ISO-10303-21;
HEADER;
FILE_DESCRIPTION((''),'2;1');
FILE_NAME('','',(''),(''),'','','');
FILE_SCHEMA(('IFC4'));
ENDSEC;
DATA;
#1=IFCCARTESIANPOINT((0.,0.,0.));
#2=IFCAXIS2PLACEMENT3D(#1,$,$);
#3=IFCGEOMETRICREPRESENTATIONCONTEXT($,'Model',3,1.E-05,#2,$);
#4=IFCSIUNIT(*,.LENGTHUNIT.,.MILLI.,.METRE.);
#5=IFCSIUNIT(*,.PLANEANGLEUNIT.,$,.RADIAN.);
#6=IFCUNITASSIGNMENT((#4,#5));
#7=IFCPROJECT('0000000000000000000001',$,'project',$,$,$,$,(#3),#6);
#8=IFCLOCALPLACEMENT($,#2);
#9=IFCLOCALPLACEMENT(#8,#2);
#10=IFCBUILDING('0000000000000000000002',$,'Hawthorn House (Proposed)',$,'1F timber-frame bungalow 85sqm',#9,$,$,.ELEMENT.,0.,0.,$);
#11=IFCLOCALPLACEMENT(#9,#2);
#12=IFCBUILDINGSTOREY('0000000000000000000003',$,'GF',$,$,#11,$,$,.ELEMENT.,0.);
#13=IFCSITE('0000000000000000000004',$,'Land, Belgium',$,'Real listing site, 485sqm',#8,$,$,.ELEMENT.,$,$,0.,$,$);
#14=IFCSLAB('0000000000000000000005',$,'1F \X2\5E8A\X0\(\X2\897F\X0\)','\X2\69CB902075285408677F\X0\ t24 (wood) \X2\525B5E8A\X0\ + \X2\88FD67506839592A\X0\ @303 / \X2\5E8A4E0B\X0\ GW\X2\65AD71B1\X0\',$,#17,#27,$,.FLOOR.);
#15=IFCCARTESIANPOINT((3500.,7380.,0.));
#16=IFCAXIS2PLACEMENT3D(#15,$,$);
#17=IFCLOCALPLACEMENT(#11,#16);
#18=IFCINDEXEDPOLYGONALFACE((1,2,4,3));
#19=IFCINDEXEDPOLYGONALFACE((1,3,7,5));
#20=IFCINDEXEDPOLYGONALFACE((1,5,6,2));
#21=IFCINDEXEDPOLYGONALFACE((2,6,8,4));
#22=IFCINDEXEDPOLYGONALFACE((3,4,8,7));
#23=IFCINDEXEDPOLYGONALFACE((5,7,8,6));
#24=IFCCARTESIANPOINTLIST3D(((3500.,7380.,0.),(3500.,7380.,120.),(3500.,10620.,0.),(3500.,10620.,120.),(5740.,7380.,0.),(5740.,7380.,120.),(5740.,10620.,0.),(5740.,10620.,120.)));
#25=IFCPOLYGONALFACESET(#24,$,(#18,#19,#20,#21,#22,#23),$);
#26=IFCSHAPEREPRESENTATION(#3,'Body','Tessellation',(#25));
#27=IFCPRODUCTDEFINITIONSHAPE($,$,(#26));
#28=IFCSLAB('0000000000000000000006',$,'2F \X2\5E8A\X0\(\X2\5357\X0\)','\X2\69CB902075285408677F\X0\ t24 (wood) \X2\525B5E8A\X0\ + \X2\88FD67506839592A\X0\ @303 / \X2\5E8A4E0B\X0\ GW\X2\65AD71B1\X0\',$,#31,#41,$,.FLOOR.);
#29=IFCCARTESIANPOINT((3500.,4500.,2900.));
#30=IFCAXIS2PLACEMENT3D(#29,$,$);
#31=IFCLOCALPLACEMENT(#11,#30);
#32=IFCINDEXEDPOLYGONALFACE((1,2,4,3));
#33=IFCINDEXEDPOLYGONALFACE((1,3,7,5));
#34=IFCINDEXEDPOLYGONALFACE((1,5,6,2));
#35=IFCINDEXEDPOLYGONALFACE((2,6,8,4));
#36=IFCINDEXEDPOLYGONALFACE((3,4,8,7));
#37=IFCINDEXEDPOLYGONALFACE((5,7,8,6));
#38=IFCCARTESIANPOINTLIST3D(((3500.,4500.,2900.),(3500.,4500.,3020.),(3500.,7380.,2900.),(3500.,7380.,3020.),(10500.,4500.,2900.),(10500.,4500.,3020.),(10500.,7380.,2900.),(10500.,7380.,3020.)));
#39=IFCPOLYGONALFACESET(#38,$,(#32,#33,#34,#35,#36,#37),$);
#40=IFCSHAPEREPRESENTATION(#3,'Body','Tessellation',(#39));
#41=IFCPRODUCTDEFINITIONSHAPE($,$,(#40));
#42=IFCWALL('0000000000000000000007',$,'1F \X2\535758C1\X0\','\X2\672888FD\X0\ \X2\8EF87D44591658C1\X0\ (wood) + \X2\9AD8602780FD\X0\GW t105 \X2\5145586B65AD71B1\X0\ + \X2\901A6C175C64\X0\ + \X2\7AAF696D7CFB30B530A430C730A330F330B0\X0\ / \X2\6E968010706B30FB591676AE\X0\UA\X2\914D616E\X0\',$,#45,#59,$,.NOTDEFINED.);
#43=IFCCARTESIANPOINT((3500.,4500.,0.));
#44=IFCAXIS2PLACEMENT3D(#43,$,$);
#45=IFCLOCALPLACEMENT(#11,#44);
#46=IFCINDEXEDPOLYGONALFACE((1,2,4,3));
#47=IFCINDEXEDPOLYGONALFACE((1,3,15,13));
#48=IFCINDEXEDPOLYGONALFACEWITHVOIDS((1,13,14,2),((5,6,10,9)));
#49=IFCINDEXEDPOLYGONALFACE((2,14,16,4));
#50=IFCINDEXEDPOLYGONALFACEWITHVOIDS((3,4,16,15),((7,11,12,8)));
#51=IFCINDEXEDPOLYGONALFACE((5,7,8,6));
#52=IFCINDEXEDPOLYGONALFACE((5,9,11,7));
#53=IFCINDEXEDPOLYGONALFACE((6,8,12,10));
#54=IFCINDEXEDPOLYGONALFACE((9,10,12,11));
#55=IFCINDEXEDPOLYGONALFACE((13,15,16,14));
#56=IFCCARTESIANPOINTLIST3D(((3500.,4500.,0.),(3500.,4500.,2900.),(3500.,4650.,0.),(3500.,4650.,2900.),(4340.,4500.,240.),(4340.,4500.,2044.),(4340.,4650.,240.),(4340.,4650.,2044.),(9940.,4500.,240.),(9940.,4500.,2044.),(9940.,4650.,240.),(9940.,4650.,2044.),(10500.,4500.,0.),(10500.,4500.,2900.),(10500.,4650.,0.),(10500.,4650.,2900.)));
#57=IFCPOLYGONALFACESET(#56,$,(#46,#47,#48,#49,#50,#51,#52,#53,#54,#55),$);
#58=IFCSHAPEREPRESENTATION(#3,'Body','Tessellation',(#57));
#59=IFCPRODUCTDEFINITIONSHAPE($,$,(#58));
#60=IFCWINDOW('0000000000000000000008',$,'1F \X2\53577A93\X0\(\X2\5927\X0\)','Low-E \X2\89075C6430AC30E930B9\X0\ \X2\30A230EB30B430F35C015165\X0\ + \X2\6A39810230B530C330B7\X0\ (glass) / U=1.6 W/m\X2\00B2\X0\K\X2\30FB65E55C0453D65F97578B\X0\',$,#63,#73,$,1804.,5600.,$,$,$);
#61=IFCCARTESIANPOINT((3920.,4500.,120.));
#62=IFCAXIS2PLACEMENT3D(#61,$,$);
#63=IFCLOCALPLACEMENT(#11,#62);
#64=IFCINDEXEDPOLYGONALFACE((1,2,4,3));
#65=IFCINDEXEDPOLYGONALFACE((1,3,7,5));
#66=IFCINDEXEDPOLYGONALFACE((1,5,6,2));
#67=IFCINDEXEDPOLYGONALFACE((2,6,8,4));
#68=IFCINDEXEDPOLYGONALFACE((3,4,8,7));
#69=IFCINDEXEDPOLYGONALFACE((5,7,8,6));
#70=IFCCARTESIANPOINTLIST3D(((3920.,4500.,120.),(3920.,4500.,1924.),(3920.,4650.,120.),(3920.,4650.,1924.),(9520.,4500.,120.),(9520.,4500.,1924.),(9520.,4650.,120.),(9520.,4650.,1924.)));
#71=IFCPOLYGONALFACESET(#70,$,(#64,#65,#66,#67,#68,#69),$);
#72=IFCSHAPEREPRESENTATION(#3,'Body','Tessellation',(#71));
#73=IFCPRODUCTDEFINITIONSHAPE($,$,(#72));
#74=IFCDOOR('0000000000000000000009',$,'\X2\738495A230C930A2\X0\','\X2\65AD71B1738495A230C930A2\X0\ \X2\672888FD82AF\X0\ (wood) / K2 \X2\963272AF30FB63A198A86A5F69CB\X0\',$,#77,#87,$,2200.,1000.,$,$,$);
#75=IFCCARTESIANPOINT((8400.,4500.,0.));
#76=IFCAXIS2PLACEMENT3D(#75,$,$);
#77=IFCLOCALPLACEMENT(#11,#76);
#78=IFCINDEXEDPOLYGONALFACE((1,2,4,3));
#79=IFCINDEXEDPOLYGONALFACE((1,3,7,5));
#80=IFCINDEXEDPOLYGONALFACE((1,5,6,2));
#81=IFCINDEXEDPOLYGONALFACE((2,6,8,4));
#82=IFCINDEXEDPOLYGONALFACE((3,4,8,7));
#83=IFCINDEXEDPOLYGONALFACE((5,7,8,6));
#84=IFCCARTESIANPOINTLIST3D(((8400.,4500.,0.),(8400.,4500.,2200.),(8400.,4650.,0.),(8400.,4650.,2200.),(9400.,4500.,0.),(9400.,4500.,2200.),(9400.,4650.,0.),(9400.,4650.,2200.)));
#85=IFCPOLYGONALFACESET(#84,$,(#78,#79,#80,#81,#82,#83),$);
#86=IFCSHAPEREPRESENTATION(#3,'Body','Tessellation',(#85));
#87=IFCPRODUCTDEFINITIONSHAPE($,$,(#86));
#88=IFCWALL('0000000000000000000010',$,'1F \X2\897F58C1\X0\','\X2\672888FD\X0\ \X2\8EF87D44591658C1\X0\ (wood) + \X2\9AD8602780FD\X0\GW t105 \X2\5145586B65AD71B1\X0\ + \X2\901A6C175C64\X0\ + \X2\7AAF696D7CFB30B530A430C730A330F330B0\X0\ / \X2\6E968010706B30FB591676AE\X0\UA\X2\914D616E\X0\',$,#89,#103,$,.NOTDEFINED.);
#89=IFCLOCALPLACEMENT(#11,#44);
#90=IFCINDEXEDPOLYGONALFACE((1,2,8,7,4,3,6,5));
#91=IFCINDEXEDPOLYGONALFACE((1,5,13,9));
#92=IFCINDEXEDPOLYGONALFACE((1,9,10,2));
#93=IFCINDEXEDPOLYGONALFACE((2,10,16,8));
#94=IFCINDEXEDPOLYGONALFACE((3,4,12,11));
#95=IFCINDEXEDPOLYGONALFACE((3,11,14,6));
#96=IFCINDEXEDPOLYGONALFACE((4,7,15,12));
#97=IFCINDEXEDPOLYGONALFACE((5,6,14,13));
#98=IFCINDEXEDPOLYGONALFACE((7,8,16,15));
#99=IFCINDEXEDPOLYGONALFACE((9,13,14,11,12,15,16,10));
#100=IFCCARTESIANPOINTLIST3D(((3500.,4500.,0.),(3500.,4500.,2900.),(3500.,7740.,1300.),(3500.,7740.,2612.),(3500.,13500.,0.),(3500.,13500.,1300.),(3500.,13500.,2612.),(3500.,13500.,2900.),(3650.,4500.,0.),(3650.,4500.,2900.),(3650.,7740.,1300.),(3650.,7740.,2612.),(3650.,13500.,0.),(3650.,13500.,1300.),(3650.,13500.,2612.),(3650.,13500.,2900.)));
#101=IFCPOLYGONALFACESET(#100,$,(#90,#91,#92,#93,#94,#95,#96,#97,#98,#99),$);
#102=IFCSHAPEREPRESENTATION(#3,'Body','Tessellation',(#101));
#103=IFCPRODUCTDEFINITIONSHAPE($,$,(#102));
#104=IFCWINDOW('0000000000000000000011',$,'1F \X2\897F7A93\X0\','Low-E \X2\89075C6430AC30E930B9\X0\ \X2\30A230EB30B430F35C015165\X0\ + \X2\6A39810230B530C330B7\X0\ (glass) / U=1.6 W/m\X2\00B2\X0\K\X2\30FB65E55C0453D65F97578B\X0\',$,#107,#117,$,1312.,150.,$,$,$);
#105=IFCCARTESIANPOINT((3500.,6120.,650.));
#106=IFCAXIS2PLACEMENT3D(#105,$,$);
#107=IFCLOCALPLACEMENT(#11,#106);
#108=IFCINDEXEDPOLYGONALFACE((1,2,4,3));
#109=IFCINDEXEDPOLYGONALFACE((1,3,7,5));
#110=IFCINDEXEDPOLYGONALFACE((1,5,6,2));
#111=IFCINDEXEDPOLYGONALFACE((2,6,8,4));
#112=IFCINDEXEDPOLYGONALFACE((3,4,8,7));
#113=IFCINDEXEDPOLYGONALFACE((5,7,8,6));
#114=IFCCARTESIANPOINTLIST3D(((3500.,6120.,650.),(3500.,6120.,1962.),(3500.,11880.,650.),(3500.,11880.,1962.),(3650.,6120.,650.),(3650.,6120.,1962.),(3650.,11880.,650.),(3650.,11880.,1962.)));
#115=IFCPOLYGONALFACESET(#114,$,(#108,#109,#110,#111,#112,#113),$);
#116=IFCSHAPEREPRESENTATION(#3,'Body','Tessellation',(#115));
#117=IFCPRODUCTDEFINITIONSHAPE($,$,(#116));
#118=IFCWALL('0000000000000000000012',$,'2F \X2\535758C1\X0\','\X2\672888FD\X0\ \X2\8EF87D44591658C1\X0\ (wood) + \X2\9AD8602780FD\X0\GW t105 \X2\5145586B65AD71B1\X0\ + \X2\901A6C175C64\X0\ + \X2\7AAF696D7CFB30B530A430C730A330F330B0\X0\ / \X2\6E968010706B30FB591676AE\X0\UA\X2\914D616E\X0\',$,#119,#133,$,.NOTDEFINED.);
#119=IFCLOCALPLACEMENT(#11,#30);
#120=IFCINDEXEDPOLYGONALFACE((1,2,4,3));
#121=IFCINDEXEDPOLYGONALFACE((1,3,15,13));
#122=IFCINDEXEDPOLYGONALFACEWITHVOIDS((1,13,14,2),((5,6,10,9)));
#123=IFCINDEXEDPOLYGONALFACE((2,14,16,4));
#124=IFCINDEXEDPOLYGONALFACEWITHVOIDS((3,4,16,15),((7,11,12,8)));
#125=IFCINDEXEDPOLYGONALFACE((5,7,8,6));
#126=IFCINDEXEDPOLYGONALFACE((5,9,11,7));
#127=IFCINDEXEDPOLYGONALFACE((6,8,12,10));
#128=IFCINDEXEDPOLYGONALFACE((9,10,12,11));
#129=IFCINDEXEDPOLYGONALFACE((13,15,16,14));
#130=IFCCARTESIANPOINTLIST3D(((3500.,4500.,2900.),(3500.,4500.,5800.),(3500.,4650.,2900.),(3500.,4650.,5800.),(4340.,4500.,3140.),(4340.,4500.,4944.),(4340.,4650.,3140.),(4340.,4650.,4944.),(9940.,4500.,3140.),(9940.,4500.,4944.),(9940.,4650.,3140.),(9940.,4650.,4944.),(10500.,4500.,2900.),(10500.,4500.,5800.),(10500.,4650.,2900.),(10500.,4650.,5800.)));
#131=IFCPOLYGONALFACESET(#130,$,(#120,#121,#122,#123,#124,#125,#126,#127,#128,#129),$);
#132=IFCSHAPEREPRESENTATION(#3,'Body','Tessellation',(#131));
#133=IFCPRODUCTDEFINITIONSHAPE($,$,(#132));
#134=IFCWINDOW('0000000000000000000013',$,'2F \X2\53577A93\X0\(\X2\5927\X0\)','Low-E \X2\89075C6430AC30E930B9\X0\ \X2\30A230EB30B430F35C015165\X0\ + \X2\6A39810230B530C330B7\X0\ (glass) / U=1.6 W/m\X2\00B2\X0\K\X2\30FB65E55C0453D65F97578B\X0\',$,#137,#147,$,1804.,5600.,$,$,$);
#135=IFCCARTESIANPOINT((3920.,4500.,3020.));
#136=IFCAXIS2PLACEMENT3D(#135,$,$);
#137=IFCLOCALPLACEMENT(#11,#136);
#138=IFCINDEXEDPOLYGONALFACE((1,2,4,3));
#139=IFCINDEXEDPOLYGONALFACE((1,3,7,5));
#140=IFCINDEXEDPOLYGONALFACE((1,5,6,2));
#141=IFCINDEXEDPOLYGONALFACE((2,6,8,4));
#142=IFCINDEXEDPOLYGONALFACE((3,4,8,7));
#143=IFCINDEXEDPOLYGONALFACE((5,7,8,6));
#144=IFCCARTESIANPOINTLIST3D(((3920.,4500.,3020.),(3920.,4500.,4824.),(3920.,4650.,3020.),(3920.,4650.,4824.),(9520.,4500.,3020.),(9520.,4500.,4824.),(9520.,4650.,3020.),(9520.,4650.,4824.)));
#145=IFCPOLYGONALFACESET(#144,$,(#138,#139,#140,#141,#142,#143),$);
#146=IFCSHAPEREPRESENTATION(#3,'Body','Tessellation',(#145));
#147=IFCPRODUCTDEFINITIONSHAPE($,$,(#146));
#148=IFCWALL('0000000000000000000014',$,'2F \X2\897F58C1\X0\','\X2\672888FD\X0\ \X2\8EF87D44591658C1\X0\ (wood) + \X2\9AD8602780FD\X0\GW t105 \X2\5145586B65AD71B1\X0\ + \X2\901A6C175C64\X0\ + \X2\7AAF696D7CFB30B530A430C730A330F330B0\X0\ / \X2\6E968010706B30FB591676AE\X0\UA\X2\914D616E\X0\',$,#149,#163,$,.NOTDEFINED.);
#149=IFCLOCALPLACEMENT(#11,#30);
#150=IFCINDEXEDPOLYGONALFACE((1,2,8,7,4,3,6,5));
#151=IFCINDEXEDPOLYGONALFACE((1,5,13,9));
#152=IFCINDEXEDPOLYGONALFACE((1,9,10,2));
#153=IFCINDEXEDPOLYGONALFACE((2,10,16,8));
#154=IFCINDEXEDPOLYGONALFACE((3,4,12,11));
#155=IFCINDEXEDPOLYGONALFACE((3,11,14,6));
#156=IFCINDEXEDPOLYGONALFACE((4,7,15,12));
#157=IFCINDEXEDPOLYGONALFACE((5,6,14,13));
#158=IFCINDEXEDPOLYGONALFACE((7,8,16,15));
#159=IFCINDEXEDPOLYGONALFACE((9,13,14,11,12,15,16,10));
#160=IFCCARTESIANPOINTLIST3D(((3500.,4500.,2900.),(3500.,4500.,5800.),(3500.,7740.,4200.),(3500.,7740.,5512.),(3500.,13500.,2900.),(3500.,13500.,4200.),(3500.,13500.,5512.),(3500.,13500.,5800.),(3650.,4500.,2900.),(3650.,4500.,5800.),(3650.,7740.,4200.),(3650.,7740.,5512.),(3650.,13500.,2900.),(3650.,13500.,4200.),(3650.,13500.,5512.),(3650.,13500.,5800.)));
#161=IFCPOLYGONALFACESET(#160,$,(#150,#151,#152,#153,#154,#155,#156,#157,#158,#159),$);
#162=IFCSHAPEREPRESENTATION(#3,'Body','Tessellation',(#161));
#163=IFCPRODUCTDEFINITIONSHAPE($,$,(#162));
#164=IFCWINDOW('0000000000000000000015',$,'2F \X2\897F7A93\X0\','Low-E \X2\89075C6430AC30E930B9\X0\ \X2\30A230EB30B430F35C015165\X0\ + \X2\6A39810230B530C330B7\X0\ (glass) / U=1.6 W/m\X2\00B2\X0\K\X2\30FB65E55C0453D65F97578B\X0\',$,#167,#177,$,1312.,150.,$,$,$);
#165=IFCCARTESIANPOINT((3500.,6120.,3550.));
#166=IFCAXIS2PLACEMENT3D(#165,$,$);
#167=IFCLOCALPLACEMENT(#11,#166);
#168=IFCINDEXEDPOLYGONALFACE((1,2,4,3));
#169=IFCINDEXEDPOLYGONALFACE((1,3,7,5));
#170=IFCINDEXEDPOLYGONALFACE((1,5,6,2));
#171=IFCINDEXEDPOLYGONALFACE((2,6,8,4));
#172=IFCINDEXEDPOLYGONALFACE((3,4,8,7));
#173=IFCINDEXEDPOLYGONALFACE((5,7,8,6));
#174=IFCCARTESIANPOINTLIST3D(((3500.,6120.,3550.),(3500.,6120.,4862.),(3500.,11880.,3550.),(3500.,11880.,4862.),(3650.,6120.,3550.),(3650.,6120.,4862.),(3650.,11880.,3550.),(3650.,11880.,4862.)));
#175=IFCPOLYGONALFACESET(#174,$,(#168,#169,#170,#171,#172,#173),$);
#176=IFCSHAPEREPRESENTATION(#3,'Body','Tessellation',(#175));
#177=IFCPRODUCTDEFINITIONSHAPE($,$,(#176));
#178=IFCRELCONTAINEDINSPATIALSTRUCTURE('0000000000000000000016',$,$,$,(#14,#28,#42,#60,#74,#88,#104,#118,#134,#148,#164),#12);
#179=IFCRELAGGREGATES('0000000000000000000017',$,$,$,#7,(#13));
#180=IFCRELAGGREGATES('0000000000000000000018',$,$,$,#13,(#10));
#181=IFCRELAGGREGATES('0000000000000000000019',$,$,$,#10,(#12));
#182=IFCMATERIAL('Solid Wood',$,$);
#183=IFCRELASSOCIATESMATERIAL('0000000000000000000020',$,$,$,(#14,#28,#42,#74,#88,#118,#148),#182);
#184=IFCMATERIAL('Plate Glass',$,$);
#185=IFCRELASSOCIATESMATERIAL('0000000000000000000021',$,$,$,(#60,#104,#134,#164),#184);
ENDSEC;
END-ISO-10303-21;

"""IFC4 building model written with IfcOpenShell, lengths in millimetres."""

from ifc_helpers import new_model, si_unit, frame, frame_2d, origin, place, context, project, spatial, rectangle, extrude, material, element, fill, save


model = new_model("IFC4")

# Units and contexts
model_context = context("Model", 3, precision=1e-05, world=origin())
ifc_project = project(units=[si_unit("LENGTHUNIT", "METRE", prefix="MILLI"), si_unit("PLANEANGLEUNIT", "RADIAN")], contexts=[model_context])

# Site, building, storey
site_placement = place(None, origin())
site = spatial("IfcSite", under=ifc_project, at=site_placement, Name="Land, Belgium", ObjectType="Real listing site, 485sqm", CompositionType="ELEMENT", RefElevation=0.0)
building_placement = place(site_placement, origin())
building = spatial("IfcBuilding", under=site, at=building_placement, Name="Hawthorn House (Proposed)", ObjectType="1F timber-frame bungalow 85sqm", CompositionType="ELEMENT", ElevationOfRefHeight=0.0, ElevationOfTerrain=0.0)
storey_placement = place(building_placement, origin())
storey = spatial("IfcBuildingStorey", under=building, at=storey_placement, Name="GF", CompositionType="ELEMENT", Elevation=0.0)

# Slabs
ifc_material_1 = material(Name="Solid Wood")
slab_1_placement = place(storey_placement, frame((3500.0, 7380.0, 0.0)))
element("IfcSlab", 1, at=slab_1_placement, inside=storey, material=ifc_material_1, Name="1F 床(西)", Description="構造用合板 t24 (wood) 剛床 + 製材根太 @303 / 床下 GW断熱", PredefinedType="FLOOR", context=model_context, shape_type="SweptSolid", body=[
    extrude(rectangle(XDim=2240.0, YDim=3240.0, at=frame_2d((1120.0, 1620.0))), frame((3500.0, 7380.0, 0.0)), (0.0, 0.0, 1.0), 120.0),
])
slab_2_placement = place(storey_placement, frame((3500.0, 4500.0, 2900.0)))
element("IfcSlab", 2, at=slab_2_placement, inside=storey, material=ifc_material_1, Name="2F 床(南)", Description="構造用合板 t24 (wood) 剛床 + 製材根太 @303 / 床下 GW断熱", PredefinedType="FLOOR", context=model_context, shape_type="SweptSolid", body=[
    extrude(rectangle(XDim=7000.0, YDim=2880.0, at=frame_2d((3500.0, 1440.0))), frame((3500.0, 4500.0, 2900.0)), (0.0, 0.0, 1.0), 120.0),
])

# Wall, openings, window, door
wall_1_placement = place(storey_placement, frame((3500.0, 4500.0, 0.0)))
wall_1 = element("IfcWall", 3, at=wall_1_placement, inside=storey, material=ifc_material_1, Name="1F 南壁", Description="木製 軸組外壁 (wood) + 高性能GW t105 充填断熱 + 通気層 + 窯業系サイディング / 準耐火・外皮UA配慮", PredefinedType="NOTDEFINED", context=model_context, shape_type="SweptSolid", body=[
    extrude(rectangle(XDim=7000.0, YDim=150.0, at=frame_2d((3500.0, 75.0))), frame((3500.0, 4500.0, 0.0)), (0.0, 0.0, 1.0), 2900.0),
])
opening_1_placement = place(storey_placement, frame((3920.0, 4500.0, 120.0)))
opening_1 = element("IfcOpeningElement", 4, at=opening_1_placement, cuts=wall_1, PredefinedType="NOTDEFINED", context=model_context, shape_type="SweptSolid", body=[
    extrude(rectangle(XDim=5600.0, YDim=150.0, at=frame_2d((2800.0, 75.0))), frame((3920.0, 4500.0, 120.0)), (0.0, 0.0, 1.0), 1804.0),
])
opening_2_placement = place(storey_placement, frame((8400.0, 4500.0, 0.0)))
opening_2 = element("IfcOpeningElement", 5, at=opening_2_placement, cuts=wall_1, PredefinedType="NOTDEFINED", context=model_context, shape_type="SweptSolid", body=[
    extrude(rectangle(XDim=1000.0, YDim=150.0, at=frame_2d((500.0, 75.0))), frame((8400.0, 4500.0, 0.0)), (0.0, 0.0, 1.0), 2200.0),
])
ifc_material_2 = material(Name="Plate Glass")
window_1_placement = place(storey_placement, frame((3920.0, 4500.0, 120.0)))
window_1 = element("IfcWindow", 6, at=window_1_placement, inside=storey, material=ifc_material_2, Name="1F 南窓(大)", Description="Low-E 複層ガラス アルゴン封入 + 樹脂サッシ (glass) / U=1.6 W/m²K・日射取得型", OverallHeight=1804.0, OverallWidth=5600.0, context=model_context, shape_type="SweptSolid", body=[
    extrude(rectangle(XDim=5600.0, YDim=150.0, at=frame_2d((2800.0, 75.0))), frame((3920.0, 4500.0, 120.0)), (0.0, 0.0, 1.0), 1804.0),
])
fill(opening_1, window_1)
door_placement = place(storey_placement, frame((8400.0, 4500.0, 0.0)))
door = element("IfcDoor", 7, at=door_placement, inside=storey, material=ifc_material_1, Name="玄関ドア", Description="断熱玄関ドア 木製芯 (wood) / K2 防犯・採風機構", OverallHeight=2200.0, OverallWidth=1000.0, context=model_context, shape_type="SweptSolid", body=[
    extrude(rectangle(XDim=1000.0, YDim=150.0, at=frame_2d((500.0, 75.0))), frame((8400.0, 4500.0, 0.0)), (0.0, 0.0, 1.0), 2200.0),
])
fill(opening_2, door)

# Walls, openings, windows
wall_2_placement = place(storey_placement, frame((3500.0, 4500.0, 0.0)))
wall_2 = element("IfcWall", 8, at=wall_2_placement, inside=storey, material=ifc_material_1, Name="1F 西壁", Description="木製 軸組外壁 (wood) + 高性能GW t105 充填断熱 + 通気層 + 窯業系サイディング / 準耐火・外皮UA配慮", PredefinedType="NOTDEFINED", context=model_context, shape_type="SweptSolid", body=[
    extrude(rectangle(XDim=150.0, YDim=9000.0, at=frame_2d((75.0, 4500.0))), frame((3500.0, 4500.0, 0.0)), (0.0, 0.0, 1.0), 2900.0),
])
opening_3_placement = place(storey_placement, frame((3500.0, 6120.0, 650.0)))
opening_3 = element("IfcOpeningElement", 9, at=opening_3_placement, cuts=wall_2, PredefinedType="NOTDEFINED", context=model_context, shape_type="SweptSolid", body=[
    extrude(rectangle(XDim=150.0, YDim=5760.0, at=frame_2d((75.0, 2880.0))), frame((3500.0, 6120.0, 650.0)), (0.0, 0.0, 1.0), 1312.0),
])
window_2_placement = place(storey_placement, frame((3500.0, 6120.0, 650.0)))
window_2 = element("IfcWindow", 10, at=window_2_placement, inside=storey, material=ifc_material_2, Name="1F 西窓", Description="Low-E 複層ガラス アルゴン封入 + 樹脂サッシ (glass) / U=1.6 W/m²K・日射取得型", OverallHeight=1312.0, OverallWidth=150.0, context=model_context, shape_type="SweptSolid", body=[
    extrude(rectangle(XDim=150.0, YDim=5760.0, at=frame_2d((75.0, 2880.0))), frame((3500.0, 6120.0, 650.0)), (0.0, 0.0, 1.0), 1312.0),
])
fill(opening_3, window_2)
wall_3_placement = place(storey_placement, frame((3500.0, 4500.0, 2900.0)))
wall_3 = element("IfcWall", 11, at=wall_3_placement, inside=storey, material=ifc_material_1, Name="2F 南壁", Description="木製 軸組外壁 (wood) + 高性能GW t105 充填断熱 + 通気層 + 窯業系サイディング / 準耐火・外皮UA配慮", PredefinedType="NOTDEFINED", context=model_context, shape_type="SweptSolid", body=[
    extrude(rectangle(XDim=7000.0, YDim=150.0, at=frame_2d((3500.0, 75.0))), frame((3500.0, 4500.0, 2900.0)), (0.0, 0.0, 1.0), 2900.0),
])
opening_4_placement = place(storey_placement, frame((3920.0, 4500.0, 3020.0)))
opening_4 = element("IfcOpeningElement", 12, at=opening_4_placement, cuts=wall_3, PredefinedType="NOTDEFINED", context=model_context, shape_type="SweptSolid", body=[
    extrude(rectangle(XDim=5600.0, YDim=150.0, at=frame_2d((2800.0, 75.0))), frame((3920.0, 4500.0, 3020.0)), (0.0, 0.0, 1.0), 1804.0),
])
window_3_placement = place(storey_placement, frame((3920.0, 4500.0, 3020.0)))
window_3 = element("IfcWindow", 13, at=window_3_placement, inside=storey, material=ifc_material_2, Name="2F 南窓(大)", Description="Low-E 複層ガラス アルゴン封入 + 樹脂サッシ (glass) / U=1.6 W/m²K・日射取得型", OverallHeight=1804.0, OverallWidth=5600.0, context=model_context, shape_type="SweptSolid", body=[
    extrude(rectangle(XDim=5600.0, YDim=150.0, at=frame_2d((2800.0, 75.0))), frame((3920.0, 4500.0, 3020.0)), (0.0, 0.0, 1.0), 1804.0),
])
fill(opening_4, window_3)
wall_4_placement = place(storey_placement, frame((3500.0, 4500.0, 2900.0)))
wall_4 = element("IfcWall", 14, at=wall_4_placement, inside=storey, material=ifc_material_1, Name="2F 西壁", Description="木製 軸組外壁 (wood) + 高性能GW t105 充填断熱 + 通気層 + 窯業系サイディング / 準耐火・外皮UA配慮", PredefinedType="NOTDEFINED", context=model_context, shape_type="SweptSolid", body=[
    extrude(rectangle(XDim=150.0, YDim=9000.0, at=frame_2d((75.0, 4500.0))), frame((3500.0, 4500.0, 2900.0)), (0.0, 0.0, 1.0), 2900.0),
])
opening_5_placement = place(storey_placement, frame((3500.0, 6120.0, 3550.0)))
opening_5 = element("IfcOpeningElement", 15, at=opening_5_placement, cuts=wall_4, PredefinedType="NOTDEFINED", context=model_context, shape_type="SweptSolid", body=[
    extrude(rectangle(XDim=150.0, YDim=5760.0, at=frame_2d((75.0, 2880.0))), frame((3500.0, 6120.0, 3550.0)), (0.0, 0.0, 1.0), 1312.0),
])
window_4_placement = place(storey_placement, frame((3500.0, 6120.0, 3550.0)))
window_4 = element("IfcWindow", 16, at=window_4_placement, inside=storey, material=ifc_material_2, Name="2F 西窓", Description="Low-E 複層ガラス アルゴン封入 + 樹脂サッシ (glass) / U=1.6 W/m²K・日射取得型", OverallHeight=1312.0, OverallWidth=150.0, context=model_context, shape_type="SweptSolid", body=[
    extrude(rectangle(XDim=150.0, YDim=5760.0, at=frame_2d((75.0, 2880.0))), frame((3500.0, 6120.0, 3550.0)), (0.0, 0.0, 1.0), 1312.0),
])
fill(opening_5, window_4)

save(model, "model.ifc")
